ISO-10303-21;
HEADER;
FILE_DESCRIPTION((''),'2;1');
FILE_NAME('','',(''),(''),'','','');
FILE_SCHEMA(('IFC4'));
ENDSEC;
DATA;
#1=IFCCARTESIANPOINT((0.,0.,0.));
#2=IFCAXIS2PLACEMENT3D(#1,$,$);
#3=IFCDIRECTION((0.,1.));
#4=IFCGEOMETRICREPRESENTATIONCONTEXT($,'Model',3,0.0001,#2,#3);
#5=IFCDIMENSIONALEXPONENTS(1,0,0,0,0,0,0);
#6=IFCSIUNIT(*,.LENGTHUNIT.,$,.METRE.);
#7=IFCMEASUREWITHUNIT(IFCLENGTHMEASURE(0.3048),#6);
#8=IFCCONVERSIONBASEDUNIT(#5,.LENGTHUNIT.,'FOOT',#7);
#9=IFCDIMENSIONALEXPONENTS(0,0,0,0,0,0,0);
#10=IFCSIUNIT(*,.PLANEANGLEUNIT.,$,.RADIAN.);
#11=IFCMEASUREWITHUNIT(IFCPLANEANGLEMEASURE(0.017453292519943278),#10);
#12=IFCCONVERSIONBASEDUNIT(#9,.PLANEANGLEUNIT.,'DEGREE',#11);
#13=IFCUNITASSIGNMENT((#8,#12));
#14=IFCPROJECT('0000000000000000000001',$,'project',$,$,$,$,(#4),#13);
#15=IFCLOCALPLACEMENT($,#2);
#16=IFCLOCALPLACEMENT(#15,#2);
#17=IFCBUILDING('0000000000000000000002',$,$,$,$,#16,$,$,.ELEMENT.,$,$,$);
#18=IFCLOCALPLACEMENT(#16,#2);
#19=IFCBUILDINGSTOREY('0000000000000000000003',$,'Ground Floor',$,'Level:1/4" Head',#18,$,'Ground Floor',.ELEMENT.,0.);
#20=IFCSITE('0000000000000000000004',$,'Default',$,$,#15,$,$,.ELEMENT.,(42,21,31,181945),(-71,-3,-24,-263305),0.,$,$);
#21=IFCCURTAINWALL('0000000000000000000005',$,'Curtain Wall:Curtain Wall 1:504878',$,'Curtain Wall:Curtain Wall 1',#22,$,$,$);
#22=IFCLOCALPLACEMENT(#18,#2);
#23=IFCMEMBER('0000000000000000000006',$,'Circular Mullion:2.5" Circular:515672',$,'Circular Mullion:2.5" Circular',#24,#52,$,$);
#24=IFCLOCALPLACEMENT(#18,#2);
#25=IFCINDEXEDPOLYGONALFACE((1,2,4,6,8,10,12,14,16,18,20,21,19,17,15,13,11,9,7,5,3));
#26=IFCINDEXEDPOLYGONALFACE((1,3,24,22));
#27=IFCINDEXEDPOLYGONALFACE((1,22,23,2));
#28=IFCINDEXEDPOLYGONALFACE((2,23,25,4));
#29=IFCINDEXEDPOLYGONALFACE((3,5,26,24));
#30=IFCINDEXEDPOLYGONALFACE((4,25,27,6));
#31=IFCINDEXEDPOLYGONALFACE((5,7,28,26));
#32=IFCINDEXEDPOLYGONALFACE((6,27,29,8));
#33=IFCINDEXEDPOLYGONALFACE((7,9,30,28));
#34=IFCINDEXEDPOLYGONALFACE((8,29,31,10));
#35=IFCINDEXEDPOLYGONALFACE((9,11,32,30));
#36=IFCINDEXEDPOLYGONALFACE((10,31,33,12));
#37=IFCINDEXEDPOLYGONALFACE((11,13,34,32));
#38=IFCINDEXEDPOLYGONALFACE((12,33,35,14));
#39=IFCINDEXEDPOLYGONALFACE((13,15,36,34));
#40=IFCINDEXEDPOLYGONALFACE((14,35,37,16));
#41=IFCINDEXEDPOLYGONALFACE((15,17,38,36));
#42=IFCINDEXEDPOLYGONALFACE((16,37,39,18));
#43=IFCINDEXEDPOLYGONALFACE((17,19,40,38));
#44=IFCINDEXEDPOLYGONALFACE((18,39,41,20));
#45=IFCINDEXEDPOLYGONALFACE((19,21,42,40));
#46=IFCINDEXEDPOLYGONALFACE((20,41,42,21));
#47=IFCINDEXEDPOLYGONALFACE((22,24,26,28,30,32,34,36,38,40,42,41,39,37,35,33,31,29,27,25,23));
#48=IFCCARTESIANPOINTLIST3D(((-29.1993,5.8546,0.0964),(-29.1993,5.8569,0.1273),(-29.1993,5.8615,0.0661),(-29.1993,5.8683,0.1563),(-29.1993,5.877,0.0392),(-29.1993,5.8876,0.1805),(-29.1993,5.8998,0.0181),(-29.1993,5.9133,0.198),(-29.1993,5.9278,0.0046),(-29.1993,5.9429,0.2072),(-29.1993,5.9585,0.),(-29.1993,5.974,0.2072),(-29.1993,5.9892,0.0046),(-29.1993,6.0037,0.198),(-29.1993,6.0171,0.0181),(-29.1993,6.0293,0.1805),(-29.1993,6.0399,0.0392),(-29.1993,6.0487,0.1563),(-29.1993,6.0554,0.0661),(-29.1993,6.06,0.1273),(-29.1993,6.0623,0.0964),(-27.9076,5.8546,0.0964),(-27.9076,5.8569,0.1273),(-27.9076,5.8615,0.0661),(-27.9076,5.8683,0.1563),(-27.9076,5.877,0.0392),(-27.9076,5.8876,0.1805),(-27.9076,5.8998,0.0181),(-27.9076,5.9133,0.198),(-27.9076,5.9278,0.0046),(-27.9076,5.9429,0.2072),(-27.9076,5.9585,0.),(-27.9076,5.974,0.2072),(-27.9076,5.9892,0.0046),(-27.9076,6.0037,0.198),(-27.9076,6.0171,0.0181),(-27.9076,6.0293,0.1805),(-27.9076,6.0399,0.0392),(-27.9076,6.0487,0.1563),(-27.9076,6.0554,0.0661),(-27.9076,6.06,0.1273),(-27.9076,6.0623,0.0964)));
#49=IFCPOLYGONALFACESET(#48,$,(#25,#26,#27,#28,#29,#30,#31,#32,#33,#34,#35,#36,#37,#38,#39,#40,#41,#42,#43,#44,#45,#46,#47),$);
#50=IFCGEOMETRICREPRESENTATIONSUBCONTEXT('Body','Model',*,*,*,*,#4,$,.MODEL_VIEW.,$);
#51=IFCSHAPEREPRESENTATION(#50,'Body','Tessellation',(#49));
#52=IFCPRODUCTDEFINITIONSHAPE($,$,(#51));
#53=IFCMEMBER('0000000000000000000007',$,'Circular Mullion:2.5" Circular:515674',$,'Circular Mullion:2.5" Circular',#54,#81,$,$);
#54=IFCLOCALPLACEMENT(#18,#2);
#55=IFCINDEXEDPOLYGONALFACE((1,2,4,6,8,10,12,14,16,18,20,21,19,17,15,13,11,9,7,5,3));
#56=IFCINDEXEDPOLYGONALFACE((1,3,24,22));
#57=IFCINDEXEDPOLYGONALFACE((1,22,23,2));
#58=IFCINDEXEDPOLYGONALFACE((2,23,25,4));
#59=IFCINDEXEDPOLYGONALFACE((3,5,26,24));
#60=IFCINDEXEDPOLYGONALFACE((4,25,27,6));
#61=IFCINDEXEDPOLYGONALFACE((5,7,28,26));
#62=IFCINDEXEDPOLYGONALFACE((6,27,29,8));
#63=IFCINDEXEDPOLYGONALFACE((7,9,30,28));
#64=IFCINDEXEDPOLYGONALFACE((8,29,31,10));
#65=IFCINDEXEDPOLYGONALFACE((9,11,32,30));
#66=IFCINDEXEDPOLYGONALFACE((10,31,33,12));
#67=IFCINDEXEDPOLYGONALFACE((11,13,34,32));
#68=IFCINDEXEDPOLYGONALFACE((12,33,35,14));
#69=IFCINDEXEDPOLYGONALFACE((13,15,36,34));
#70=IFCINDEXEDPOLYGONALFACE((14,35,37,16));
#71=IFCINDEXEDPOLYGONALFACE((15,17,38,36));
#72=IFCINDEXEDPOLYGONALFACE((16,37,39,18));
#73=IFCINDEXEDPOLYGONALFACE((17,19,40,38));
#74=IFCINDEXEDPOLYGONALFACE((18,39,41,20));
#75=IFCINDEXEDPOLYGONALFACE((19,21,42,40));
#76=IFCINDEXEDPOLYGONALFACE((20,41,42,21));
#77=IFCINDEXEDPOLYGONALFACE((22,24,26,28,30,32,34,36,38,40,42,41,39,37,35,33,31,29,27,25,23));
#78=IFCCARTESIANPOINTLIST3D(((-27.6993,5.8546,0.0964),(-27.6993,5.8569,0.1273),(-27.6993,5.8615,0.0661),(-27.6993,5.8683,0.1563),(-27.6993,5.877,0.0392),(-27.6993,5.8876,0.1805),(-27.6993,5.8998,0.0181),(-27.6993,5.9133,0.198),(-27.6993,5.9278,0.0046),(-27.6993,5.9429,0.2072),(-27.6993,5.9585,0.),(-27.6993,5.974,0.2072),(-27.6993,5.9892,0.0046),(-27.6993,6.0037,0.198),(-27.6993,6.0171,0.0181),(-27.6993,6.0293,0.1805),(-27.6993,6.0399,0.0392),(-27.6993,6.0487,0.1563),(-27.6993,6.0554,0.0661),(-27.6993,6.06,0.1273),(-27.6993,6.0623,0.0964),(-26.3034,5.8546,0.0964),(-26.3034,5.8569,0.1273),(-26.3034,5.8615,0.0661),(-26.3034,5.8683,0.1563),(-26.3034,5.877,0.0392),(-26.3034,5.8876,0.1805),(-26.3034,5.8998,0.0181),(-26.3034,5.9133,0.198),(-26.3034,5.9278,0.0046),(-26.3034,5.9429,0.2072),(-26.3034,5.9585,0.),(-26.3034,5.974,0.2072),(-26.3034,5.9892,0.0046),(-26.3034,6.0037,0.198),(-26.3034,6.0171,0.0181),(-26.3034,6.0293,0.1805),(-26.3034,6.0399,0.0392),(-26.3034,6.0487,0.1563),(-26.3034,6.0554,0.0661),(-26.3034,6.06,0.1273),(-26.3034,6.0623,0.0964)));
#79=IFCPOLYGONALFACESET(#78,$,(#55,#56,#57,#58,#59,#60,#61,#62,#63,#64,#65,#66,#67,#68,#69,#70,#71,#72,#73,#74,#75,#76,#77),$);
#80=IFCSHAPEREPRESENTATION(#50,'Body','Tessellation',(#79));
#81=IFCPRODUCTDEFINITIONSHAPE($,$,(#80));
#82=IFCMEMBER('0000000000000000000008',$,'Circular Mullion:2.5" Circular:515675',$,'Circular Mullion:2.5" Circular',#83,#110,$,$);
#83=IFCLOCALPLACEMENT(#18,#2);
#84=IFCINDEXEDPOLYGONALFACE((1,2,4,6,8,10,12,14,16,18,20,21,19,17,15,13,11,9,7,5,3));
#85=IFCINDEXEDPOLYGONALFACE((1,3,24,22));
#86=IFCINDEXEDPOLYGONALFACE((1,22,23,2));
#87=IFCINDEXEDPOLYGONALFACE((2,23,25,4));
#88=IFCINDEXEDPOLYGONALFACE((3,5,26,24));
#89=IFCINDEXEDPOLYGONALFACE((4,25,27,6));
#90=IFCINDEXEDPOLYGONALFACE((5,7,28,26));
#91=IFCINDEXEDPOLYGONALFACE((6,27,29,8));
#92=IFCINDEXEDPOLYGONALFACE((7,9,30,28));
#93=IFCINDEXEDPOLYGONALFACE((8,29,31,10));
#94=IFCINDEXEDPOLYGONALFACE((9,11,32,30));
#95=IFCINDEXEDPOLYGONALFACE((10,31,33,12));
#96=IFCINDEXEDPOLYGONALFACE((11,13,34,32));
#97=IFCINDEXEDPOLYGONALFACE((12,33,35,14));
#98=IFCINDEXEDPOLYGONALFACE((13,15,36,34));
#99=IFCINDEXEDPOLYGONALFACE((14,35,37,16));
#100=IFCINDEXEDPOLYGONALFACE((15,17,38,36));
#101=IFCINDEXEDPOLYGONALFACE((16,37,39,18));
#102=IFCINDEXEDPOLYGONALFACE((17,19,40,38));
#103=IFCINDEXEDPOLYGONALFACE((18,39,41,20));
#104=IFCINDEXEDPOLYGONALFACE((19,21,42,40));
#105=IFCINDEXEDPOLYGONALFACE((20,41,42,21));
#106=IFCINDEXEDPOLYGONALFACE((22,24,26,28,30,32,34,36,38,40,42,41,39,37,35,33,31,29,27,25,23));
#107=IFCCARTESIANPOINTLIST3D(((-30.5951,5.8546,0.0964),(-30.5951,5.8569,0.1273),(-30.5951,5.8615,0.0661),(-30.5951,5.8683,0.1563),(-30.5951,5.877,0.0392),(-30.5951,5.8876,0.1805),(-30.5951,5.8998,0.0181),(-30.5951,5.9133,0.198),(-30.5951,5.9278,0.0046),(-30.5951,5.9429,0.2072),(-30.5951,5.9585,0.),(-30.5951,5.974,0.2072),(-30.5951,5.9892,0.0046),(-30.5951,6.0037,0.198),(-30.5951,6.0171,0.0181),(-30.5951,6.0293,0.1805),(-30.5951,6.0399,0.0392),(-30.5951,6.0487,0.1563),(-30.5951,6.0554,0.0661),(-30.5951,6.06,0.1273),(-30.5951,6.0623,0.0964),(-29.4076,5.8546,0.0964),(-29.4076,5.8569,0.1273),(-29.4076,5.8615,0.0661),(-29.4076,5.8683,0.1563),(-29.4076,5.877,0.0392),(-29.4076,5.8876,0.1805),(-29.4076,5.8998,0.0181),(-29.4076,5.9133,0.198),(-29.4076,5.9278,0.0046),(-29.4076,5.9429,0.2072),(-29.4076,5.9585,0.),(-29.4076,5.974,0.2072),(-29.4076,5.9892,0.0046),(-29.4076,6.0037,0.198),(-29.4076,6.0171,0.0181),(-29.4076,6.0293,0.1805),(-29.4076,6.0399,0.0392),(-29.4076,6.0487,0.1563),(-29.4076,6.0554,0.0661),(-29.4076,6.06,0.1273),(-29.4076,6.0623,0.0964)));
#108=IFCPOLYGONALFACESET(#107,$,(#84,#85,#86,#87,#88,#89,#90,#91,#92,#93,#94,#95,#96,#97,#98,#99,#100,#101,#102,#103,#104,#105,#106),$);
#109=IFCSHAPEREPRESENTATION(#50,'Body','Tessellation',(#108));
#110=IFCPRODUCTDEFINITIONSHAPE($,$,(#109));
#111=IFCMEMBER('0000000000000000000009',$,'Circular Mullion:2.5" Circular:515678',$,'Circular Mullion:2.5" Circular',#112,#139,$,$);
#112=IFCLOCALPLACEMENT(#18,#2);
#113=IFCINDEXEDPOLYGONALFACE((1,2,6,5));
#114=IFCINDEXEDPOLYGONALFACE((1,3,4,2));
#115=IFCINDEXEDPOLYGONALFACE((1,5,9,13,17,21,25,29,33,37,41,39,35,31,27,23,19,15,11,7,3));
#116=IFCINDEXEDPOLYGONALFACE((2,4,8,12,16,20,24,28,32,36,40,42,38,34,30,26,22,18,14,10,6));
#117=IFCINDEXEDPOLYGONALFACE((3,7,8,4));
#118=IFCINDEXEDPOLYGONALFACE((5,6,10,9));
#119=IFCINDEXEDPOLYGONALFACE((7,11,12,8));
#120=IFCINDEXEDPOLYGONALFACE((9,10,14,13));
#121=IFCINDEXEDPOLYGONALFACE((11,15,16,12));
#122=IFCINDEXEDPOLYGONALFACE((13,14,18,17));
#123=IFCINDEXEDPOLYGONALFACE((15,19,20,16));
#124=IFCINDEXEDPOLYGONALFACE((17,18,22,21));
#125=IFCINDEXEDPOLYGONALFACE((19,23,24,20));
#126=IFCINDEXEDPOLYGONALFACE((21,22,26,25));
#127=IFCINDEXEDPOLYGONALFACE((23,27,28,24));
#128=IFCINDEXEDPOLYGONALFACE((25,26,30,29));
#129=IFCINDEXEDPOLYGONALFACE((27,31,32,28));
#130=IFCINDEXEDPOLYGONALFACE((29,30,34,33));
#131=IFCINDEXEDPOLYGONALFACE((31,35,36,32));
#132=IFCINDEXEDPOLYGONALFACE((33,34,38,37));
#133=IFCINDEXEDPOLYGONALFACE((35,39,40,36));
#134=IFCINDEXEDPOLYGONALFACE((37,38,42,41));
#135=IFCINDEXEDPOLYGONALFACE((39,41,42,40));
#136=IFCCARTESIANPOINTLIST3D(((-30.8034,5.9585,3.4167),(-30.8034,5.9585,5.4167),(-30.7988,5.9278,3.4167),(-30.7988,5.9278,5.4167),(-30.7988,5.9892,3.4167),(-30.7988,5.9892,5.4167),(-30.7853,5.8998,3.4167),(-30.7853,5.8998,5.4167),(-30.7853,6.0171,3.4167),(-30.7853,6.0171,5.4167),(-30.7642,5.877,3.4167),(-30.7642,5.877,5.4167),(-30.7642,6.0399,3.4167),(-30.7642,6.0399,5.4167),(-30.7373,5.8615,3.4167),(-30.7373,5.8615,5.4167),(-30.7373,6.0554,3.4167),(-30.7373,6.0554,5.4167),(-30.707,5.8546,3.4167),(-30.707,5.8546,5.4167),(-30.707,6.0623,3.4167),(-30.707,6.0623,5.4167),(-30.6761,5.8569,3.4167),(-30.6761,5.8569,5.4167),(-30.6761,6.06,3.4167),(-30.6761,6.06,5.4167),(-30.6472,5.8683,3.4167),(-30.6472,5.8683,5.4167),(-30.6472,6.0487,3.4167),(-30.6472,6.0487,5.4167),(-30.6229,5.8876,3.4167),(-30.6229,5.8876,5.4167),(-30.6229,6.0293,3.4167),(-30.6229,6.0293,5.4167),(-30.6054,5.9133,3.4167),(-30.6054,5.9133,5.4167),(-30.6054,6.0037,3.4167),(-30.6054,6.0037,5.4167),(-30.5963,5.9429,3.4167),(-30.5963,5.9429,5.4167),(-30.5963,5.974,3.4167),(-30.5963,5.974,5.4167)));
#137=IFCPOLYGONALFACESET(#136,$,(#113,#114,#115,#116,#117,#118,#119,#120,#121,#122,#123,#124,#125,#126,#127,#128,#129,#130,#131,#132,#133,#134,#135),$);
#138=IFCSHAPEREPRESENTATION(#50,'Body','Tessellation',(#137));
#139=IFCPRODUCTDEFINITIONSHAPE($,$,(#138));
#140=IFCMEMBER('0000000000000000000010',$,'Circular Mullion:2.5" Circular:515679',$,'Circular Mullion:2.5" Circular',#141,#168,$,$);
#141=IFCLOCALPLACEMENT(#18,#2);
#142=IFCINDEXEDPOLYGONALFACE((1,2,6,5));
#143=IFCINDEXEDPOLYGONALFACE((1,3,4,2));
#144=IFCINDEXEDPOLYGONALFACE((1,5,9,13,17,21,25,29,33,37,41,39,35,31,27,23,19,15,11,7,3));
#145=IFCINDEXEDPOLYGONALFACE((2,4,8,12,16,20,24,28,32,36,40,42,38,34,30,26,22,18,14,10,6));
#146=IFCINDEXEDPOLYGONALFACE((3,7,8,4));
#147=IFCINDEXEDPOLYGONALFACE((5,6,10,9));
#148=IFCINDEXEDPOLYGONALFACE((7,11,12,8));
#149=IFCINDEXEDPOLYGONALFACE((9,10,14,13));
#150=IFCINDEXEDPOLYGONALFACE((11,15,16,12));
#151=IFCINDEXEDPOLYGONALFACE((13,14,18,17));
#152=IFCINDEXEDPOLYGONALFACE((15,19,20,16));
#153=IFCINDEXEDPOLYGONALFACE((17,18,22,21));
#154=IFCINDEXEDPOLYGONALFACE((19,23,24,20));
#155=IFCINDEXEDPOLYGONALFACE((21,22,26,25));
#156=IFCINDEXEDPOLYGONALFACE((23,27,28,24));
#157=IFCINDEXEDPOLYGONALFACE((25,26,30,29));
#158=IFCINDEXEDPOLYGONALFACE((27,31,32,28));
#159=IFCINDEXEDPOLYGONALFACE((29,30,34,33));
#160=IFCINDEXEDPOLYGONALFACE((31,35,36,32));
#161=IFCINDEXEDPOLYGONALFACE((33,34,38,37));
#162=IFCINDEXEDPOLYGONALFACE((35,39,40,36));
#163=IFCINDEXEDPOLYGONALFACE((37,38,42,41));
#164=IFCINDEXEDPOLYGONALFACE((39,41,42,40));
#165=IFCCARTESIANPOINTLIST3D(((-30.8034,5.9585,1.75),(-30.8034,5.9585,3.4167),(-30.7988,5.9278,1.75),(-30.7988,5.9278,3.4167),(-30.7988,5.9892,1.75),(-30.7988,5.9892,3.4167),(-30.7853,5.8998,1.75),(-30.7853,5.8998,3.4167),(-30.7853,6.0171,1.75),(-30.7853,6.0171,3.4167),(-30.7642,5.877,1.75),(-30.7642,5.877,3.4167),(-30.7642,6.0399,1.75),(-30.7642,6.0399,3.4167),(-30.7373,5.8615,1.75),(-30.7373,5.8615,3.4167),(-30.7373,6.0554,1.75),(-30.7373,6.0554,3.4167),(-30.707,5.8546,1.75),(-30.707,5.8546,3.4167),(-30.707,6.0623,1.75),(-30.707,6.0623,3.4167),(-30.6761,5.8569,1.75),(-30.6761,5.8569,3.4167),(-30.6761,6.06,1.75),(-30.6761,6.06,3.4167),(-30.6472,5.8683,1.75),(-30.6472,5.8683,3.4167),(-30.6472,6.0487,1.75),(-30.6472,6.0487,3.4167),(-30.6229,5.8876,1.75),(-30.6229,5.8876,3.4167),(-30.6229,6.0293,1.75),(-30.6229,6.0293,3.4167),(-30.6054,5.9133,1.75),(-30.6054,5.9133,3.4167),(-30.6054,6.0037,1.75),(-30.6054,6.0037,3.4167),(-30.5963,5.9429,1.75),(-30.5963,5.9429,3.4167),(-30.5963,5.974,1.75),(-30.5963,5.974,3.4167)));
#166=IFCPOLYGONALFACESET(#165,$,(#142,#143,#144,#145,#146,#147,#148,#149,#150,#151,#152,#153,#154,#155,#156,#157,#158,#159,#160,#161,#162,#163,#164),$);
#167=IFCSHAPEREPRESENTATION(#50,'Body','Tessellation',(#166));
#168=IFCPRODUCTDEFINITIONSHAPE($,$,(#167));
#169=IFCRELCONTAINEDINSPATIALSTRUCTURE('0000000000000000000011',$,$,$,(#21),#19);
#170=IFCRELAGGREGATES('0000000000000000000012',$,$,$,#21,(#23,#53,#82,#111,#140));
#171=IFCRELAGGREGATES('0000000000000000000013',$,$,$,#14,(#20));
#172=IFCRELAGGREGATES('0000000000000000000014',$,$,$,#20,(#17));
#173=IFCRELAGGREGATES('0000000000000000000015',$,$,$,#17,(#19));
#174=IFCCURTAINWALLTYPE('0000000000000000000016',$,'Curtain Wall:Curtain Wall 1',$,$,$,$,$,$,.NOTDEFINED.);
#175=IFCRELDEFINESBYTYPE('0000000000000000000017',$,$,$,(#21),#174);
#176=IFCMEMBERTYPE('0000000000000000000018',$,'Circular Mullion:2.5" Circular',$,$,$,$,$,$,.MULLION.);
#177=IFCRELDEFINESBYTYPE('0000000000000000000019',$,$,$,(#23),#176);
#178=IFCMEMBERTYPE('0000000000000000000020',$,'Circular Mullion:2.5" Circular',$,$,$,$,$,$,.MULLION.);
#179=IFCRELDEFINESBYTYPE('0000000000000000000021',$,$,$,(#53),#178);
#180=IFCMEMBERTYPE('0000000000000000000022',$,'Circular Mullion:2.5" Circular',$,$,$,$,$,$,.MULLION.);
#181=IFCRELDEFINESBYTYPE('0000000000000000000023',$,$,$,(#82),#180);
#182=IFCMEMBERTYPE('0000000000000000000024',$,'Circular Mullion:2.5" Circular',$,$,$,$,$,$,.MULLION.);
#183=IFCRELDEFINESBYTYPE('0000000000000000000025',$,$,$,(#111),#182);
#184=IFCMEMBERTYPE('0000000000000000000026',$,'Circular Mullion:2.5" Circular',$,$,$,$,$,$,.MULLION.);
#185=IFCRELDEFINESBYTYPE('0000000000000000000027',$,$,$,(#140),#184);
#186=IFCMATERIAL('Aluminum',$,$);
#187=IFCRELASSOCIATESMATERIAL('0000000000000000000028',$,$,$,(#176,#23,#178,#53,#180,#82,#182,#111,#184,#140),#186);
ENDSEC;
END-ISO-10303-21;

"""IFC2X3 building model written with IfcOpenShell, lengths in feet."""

from ifc_helpers import new_model, entity, si_unit, converted_unit, direction, frame, frame_2d, origin, place, context, subcontext, project, spatial, circle, extrude, source, transform, mapped, material, type_object, type_shapes, element, aggregate, save


model = new_model("IFC2X3")

# Units and contexts
model_context = context("Model", 3, precision=0.0001, world=origin(), true_north=direction((0.0, 1.0)))
body_context = subcontext(model_context, "Body", "Model", "MODEL_VIEW")
ifc_project = project(units=[converted_unit("LENGTHUNIT", "FOOT", entity("IfcLengthMeasure", 0.3048), si_unit("LENGTHUNIT", "METRE"), dimensions=[1, 0, 0, 0, 0, 0, 0]), converted_unit("PLANEANGLEUNIT", "DEGREE", entity("IfcPlaneAngleMeasure", 0.017453292519943278), si_unit("PLANEANGLEUNIT", "RADIAN"), dimensions=[0, 0, 0, 0, 0, 0, 0])], contexts=[model_context])

# Site, building, storey
site_placement = place(None, origin())
site = spatial("IfcSite", under=ifc_project, at=site_placement, Name="Default", CompositionType="ELEMENT", RefLatitude=(42, 21, 31, 181945), RefLongitude=(-71, -3, -24, -263305), RefElevation=0.0)
building_placement = place(site_placement, origin())
building = spatial("IfcBuilding", under=site, at=building_placement, CompositionType="ELEMENT")
storey_placement = place(building_placement, origin())
storey = spatial("IfcBuildingStorey", under=building, at=storey_placement, Name="Ground Floor", ObjectType="Level:1/4\" Head", LongName="Ground Floor", CompositionType="ELEMENT", Elevation=0.0)

# Curtain wall, members
curtain_wall_type = type_object("IfcCurtainWallType", Name="Curtain Wall:Curtain Wall 1", PredefinedType="NOTDEFINED")
curtain_wall_placement = place(storey_placement, origin())
curtain_wall = element("IfcCurtainWall", 1, at=curtain_wall_placement, inside=storey, type_object=curtain_wall_type, Name="Curtain Wall:Curtain Wall 1:504878", ObjectType="Curtain Wall:Curtain Wall 1")
ifc_material_1 = material(Name="Aluminum")
member_type_1 = type_object("IfcMemberType", Name="Circular Mullion:2.5\" Circular", PredefinedType="MULLION", material=ifc_material_1)
shared_shape_1 = source(origin(), body_context, "Body", "SweptSolid", [
    extrude(circle(Radius=0.1042, at=frame_2d((0.0, 0.0), x_axis=(1.0, 0.0))), frame((-0.1042, 0.0, -1.2917)), (0.0, 0.0, 1.0), 1.2917),
])
type_shapes(member_type_1, [shared_shape_1])
member_1_placement = place(curtain_wall_placement, frame((-27.9076, 5.9585, 0.0), z_axis=(1.0, 0.0, 0.0), x_axis=(0.0, 0.0, -1.0)))
member_1 = element("IfcMember", 2, at=member_1_placement, type_object=member_type_1, material=ifc_material_1, Name="Circular Mullion:2.5\" Circular:515672", ObjectType="Circular Mullion:2.5\" Circular", context=body_context, shape_type="MappedRepresentation", body=[
    mapped(shared_shape_1, transform((0.0, 0.0, 0.0), scale=1.0)),
])
member_type_2 = type_object("IfcMemberType", Name="Circular Mullion:2.5\" Circular", PredefinedType="MULLION", material=ifc_material_1)
shared_shape_2 = source(origin(), body_context, "Body", "SweptSolid", [
    extrude(circle(Radius=0.1042, at=frame_2d((0.0, 0.0), x_axis=(1.0, 0.0))), frame((-0.1042, 0.0, -1.3958)), (0.0, 0.0, 1.0), 1.3958),
])
type_shapes(member_type_2, [shared_shape_2])
member_2_placement = place(curtain_wall_placement, frame((-26.3034, 5.9585, 0.0), z_axis=(1.0, 0.0, 0.0), x_axis=(0.0, 0.0, -1.0)))
member_2 = element("IfcMember", 3, at=member_2_placement, type_object=member_type_2, material=ifc_material_1, Name="Circular Mullion:2.5\" Circular:515674", ObjectType="Circular Mullion:2.5\" Circular", context=body_context, shape_type="MappedRepresentation", body=[
    mapped(shared_shape_2, transform((0.0, 0.0, 0.0), scale=1.0)),
])
member_type_3 = type_object("IfcMemberType", Name="Circular Mullion:2.5\" Circular", PredefinedType="MULLION", material=ifc_material_1)
shared_shape_3 = source(origin(), body_context, "Body", "SweptSolid", [
    extrude(circle(Radius=0.1042, at=frame_2d((0.0, 0.0), x_axis=(1.0, 0.0))), frame((-0.1042, 0.0, -1.1875)), (0.0, 0.0, 1.0), 1.1875),
])
type_shapes(member_type_3, [shared_shape_3])
member_3_placement = place(curtain_wall_placement, frame((-29.4076, 5.9585, 0.0), z_axis=(1.0, 0.0, 0.0), x_axis=(0.0, 0.0, -1.0)))
member_3 = element("IfcMember", 4, at=member_3_placement, type_object=member_type_3, material=ifc_material_1, Name="Circular Mullion:2.5\" Circular:515675", ObjectType="Circular Mullion:2.5\" Circular", context=body_context, shape_type="MappedRepresentation", body=[
    mapped(shared_shape_3, transform((0.0, 0.0, 0.0), scale=1.0)),
])
member_type_4 = type_object("IfcMemberType", Name="Circular Mullion:2.5\" Circular", PredefinedType="MULLION", material=ifc_material_1)
shared_shape_4 = source(origin(), body_context, "Body", "SweptSolid", [
    extrude(circle(Radius=0.1042, at=frame_2d((0.0, 0.0), x_axis=(1.0, 0.0))), frame((-0.1042, 0.0, -2.0)), (0.0, 0.0, 1.0), 2.0),
])
type_shapes(member_type_4, [shared_shape_4])
member_4_placement = place(curtain_wall_placement, frame((-30.8034, 5.9585, 3.4167), z_axis=(0.0, 0.0, -1.0), x_axis=(-1.0, 0.0, 0.0)))
member_4 = element("IfcMember", 5, at=member_4_placement, type_object=member_type_4, material=ifc_material_1, Name="Circular Mullion:2.5\" Circular:515678", ObjectType="Circular Mullion:2.5\" Circular", context=body_context, shape_type="MappedRepresentation", body=[
    mapped(shared_shape_4, transform((0.0, 0.0, 0.0), scale=1.0)),
])
member_type_5 = type_object("IfcMemberType", Name="Circular Mullion:2.5\" Circular", PredefinedType="MULLION", material=ifc_material_1)
shared_shape_5 = source(origin(), body_context, "Body", "SweptSolid", [
    extrude(circle(Radius=0.1042, at=frame_2d((0.0, 0.0), x_axis=(1.0, 0.0))), frame((-0.1042, 0.0, -1.6667)), (0.0, 0.0, 1.0), 1.6667),
])
type_shapes(member_type_5, [shared_shape_5])
member_5_placement = place(curtain_wall_placement, frame((-30.8034, 5.9585, 1.75), z_axis=(0.0, 0.0, -1.0), x_axis=(-1.0, 0.0, 0.0)))
member_5 = element("IfcMember", 6, at=member_5_placement, type_object=member_type_5, material=ifc_material_1, Name="Circular Mullion:2.5\" Circular:515679", ObjectType="Circular Mullion:2.5\" Circular", context=body_context, shape_type="MappedRepresentation", body=[
    mapped(shared_shape_5, transform((0.0, 0.0, 0.0), scale=1.0)),
])
aggregate(curtain_wall, [member_1, member_2, member_3, member_4, member_5])

save(model, "model.ifc")
